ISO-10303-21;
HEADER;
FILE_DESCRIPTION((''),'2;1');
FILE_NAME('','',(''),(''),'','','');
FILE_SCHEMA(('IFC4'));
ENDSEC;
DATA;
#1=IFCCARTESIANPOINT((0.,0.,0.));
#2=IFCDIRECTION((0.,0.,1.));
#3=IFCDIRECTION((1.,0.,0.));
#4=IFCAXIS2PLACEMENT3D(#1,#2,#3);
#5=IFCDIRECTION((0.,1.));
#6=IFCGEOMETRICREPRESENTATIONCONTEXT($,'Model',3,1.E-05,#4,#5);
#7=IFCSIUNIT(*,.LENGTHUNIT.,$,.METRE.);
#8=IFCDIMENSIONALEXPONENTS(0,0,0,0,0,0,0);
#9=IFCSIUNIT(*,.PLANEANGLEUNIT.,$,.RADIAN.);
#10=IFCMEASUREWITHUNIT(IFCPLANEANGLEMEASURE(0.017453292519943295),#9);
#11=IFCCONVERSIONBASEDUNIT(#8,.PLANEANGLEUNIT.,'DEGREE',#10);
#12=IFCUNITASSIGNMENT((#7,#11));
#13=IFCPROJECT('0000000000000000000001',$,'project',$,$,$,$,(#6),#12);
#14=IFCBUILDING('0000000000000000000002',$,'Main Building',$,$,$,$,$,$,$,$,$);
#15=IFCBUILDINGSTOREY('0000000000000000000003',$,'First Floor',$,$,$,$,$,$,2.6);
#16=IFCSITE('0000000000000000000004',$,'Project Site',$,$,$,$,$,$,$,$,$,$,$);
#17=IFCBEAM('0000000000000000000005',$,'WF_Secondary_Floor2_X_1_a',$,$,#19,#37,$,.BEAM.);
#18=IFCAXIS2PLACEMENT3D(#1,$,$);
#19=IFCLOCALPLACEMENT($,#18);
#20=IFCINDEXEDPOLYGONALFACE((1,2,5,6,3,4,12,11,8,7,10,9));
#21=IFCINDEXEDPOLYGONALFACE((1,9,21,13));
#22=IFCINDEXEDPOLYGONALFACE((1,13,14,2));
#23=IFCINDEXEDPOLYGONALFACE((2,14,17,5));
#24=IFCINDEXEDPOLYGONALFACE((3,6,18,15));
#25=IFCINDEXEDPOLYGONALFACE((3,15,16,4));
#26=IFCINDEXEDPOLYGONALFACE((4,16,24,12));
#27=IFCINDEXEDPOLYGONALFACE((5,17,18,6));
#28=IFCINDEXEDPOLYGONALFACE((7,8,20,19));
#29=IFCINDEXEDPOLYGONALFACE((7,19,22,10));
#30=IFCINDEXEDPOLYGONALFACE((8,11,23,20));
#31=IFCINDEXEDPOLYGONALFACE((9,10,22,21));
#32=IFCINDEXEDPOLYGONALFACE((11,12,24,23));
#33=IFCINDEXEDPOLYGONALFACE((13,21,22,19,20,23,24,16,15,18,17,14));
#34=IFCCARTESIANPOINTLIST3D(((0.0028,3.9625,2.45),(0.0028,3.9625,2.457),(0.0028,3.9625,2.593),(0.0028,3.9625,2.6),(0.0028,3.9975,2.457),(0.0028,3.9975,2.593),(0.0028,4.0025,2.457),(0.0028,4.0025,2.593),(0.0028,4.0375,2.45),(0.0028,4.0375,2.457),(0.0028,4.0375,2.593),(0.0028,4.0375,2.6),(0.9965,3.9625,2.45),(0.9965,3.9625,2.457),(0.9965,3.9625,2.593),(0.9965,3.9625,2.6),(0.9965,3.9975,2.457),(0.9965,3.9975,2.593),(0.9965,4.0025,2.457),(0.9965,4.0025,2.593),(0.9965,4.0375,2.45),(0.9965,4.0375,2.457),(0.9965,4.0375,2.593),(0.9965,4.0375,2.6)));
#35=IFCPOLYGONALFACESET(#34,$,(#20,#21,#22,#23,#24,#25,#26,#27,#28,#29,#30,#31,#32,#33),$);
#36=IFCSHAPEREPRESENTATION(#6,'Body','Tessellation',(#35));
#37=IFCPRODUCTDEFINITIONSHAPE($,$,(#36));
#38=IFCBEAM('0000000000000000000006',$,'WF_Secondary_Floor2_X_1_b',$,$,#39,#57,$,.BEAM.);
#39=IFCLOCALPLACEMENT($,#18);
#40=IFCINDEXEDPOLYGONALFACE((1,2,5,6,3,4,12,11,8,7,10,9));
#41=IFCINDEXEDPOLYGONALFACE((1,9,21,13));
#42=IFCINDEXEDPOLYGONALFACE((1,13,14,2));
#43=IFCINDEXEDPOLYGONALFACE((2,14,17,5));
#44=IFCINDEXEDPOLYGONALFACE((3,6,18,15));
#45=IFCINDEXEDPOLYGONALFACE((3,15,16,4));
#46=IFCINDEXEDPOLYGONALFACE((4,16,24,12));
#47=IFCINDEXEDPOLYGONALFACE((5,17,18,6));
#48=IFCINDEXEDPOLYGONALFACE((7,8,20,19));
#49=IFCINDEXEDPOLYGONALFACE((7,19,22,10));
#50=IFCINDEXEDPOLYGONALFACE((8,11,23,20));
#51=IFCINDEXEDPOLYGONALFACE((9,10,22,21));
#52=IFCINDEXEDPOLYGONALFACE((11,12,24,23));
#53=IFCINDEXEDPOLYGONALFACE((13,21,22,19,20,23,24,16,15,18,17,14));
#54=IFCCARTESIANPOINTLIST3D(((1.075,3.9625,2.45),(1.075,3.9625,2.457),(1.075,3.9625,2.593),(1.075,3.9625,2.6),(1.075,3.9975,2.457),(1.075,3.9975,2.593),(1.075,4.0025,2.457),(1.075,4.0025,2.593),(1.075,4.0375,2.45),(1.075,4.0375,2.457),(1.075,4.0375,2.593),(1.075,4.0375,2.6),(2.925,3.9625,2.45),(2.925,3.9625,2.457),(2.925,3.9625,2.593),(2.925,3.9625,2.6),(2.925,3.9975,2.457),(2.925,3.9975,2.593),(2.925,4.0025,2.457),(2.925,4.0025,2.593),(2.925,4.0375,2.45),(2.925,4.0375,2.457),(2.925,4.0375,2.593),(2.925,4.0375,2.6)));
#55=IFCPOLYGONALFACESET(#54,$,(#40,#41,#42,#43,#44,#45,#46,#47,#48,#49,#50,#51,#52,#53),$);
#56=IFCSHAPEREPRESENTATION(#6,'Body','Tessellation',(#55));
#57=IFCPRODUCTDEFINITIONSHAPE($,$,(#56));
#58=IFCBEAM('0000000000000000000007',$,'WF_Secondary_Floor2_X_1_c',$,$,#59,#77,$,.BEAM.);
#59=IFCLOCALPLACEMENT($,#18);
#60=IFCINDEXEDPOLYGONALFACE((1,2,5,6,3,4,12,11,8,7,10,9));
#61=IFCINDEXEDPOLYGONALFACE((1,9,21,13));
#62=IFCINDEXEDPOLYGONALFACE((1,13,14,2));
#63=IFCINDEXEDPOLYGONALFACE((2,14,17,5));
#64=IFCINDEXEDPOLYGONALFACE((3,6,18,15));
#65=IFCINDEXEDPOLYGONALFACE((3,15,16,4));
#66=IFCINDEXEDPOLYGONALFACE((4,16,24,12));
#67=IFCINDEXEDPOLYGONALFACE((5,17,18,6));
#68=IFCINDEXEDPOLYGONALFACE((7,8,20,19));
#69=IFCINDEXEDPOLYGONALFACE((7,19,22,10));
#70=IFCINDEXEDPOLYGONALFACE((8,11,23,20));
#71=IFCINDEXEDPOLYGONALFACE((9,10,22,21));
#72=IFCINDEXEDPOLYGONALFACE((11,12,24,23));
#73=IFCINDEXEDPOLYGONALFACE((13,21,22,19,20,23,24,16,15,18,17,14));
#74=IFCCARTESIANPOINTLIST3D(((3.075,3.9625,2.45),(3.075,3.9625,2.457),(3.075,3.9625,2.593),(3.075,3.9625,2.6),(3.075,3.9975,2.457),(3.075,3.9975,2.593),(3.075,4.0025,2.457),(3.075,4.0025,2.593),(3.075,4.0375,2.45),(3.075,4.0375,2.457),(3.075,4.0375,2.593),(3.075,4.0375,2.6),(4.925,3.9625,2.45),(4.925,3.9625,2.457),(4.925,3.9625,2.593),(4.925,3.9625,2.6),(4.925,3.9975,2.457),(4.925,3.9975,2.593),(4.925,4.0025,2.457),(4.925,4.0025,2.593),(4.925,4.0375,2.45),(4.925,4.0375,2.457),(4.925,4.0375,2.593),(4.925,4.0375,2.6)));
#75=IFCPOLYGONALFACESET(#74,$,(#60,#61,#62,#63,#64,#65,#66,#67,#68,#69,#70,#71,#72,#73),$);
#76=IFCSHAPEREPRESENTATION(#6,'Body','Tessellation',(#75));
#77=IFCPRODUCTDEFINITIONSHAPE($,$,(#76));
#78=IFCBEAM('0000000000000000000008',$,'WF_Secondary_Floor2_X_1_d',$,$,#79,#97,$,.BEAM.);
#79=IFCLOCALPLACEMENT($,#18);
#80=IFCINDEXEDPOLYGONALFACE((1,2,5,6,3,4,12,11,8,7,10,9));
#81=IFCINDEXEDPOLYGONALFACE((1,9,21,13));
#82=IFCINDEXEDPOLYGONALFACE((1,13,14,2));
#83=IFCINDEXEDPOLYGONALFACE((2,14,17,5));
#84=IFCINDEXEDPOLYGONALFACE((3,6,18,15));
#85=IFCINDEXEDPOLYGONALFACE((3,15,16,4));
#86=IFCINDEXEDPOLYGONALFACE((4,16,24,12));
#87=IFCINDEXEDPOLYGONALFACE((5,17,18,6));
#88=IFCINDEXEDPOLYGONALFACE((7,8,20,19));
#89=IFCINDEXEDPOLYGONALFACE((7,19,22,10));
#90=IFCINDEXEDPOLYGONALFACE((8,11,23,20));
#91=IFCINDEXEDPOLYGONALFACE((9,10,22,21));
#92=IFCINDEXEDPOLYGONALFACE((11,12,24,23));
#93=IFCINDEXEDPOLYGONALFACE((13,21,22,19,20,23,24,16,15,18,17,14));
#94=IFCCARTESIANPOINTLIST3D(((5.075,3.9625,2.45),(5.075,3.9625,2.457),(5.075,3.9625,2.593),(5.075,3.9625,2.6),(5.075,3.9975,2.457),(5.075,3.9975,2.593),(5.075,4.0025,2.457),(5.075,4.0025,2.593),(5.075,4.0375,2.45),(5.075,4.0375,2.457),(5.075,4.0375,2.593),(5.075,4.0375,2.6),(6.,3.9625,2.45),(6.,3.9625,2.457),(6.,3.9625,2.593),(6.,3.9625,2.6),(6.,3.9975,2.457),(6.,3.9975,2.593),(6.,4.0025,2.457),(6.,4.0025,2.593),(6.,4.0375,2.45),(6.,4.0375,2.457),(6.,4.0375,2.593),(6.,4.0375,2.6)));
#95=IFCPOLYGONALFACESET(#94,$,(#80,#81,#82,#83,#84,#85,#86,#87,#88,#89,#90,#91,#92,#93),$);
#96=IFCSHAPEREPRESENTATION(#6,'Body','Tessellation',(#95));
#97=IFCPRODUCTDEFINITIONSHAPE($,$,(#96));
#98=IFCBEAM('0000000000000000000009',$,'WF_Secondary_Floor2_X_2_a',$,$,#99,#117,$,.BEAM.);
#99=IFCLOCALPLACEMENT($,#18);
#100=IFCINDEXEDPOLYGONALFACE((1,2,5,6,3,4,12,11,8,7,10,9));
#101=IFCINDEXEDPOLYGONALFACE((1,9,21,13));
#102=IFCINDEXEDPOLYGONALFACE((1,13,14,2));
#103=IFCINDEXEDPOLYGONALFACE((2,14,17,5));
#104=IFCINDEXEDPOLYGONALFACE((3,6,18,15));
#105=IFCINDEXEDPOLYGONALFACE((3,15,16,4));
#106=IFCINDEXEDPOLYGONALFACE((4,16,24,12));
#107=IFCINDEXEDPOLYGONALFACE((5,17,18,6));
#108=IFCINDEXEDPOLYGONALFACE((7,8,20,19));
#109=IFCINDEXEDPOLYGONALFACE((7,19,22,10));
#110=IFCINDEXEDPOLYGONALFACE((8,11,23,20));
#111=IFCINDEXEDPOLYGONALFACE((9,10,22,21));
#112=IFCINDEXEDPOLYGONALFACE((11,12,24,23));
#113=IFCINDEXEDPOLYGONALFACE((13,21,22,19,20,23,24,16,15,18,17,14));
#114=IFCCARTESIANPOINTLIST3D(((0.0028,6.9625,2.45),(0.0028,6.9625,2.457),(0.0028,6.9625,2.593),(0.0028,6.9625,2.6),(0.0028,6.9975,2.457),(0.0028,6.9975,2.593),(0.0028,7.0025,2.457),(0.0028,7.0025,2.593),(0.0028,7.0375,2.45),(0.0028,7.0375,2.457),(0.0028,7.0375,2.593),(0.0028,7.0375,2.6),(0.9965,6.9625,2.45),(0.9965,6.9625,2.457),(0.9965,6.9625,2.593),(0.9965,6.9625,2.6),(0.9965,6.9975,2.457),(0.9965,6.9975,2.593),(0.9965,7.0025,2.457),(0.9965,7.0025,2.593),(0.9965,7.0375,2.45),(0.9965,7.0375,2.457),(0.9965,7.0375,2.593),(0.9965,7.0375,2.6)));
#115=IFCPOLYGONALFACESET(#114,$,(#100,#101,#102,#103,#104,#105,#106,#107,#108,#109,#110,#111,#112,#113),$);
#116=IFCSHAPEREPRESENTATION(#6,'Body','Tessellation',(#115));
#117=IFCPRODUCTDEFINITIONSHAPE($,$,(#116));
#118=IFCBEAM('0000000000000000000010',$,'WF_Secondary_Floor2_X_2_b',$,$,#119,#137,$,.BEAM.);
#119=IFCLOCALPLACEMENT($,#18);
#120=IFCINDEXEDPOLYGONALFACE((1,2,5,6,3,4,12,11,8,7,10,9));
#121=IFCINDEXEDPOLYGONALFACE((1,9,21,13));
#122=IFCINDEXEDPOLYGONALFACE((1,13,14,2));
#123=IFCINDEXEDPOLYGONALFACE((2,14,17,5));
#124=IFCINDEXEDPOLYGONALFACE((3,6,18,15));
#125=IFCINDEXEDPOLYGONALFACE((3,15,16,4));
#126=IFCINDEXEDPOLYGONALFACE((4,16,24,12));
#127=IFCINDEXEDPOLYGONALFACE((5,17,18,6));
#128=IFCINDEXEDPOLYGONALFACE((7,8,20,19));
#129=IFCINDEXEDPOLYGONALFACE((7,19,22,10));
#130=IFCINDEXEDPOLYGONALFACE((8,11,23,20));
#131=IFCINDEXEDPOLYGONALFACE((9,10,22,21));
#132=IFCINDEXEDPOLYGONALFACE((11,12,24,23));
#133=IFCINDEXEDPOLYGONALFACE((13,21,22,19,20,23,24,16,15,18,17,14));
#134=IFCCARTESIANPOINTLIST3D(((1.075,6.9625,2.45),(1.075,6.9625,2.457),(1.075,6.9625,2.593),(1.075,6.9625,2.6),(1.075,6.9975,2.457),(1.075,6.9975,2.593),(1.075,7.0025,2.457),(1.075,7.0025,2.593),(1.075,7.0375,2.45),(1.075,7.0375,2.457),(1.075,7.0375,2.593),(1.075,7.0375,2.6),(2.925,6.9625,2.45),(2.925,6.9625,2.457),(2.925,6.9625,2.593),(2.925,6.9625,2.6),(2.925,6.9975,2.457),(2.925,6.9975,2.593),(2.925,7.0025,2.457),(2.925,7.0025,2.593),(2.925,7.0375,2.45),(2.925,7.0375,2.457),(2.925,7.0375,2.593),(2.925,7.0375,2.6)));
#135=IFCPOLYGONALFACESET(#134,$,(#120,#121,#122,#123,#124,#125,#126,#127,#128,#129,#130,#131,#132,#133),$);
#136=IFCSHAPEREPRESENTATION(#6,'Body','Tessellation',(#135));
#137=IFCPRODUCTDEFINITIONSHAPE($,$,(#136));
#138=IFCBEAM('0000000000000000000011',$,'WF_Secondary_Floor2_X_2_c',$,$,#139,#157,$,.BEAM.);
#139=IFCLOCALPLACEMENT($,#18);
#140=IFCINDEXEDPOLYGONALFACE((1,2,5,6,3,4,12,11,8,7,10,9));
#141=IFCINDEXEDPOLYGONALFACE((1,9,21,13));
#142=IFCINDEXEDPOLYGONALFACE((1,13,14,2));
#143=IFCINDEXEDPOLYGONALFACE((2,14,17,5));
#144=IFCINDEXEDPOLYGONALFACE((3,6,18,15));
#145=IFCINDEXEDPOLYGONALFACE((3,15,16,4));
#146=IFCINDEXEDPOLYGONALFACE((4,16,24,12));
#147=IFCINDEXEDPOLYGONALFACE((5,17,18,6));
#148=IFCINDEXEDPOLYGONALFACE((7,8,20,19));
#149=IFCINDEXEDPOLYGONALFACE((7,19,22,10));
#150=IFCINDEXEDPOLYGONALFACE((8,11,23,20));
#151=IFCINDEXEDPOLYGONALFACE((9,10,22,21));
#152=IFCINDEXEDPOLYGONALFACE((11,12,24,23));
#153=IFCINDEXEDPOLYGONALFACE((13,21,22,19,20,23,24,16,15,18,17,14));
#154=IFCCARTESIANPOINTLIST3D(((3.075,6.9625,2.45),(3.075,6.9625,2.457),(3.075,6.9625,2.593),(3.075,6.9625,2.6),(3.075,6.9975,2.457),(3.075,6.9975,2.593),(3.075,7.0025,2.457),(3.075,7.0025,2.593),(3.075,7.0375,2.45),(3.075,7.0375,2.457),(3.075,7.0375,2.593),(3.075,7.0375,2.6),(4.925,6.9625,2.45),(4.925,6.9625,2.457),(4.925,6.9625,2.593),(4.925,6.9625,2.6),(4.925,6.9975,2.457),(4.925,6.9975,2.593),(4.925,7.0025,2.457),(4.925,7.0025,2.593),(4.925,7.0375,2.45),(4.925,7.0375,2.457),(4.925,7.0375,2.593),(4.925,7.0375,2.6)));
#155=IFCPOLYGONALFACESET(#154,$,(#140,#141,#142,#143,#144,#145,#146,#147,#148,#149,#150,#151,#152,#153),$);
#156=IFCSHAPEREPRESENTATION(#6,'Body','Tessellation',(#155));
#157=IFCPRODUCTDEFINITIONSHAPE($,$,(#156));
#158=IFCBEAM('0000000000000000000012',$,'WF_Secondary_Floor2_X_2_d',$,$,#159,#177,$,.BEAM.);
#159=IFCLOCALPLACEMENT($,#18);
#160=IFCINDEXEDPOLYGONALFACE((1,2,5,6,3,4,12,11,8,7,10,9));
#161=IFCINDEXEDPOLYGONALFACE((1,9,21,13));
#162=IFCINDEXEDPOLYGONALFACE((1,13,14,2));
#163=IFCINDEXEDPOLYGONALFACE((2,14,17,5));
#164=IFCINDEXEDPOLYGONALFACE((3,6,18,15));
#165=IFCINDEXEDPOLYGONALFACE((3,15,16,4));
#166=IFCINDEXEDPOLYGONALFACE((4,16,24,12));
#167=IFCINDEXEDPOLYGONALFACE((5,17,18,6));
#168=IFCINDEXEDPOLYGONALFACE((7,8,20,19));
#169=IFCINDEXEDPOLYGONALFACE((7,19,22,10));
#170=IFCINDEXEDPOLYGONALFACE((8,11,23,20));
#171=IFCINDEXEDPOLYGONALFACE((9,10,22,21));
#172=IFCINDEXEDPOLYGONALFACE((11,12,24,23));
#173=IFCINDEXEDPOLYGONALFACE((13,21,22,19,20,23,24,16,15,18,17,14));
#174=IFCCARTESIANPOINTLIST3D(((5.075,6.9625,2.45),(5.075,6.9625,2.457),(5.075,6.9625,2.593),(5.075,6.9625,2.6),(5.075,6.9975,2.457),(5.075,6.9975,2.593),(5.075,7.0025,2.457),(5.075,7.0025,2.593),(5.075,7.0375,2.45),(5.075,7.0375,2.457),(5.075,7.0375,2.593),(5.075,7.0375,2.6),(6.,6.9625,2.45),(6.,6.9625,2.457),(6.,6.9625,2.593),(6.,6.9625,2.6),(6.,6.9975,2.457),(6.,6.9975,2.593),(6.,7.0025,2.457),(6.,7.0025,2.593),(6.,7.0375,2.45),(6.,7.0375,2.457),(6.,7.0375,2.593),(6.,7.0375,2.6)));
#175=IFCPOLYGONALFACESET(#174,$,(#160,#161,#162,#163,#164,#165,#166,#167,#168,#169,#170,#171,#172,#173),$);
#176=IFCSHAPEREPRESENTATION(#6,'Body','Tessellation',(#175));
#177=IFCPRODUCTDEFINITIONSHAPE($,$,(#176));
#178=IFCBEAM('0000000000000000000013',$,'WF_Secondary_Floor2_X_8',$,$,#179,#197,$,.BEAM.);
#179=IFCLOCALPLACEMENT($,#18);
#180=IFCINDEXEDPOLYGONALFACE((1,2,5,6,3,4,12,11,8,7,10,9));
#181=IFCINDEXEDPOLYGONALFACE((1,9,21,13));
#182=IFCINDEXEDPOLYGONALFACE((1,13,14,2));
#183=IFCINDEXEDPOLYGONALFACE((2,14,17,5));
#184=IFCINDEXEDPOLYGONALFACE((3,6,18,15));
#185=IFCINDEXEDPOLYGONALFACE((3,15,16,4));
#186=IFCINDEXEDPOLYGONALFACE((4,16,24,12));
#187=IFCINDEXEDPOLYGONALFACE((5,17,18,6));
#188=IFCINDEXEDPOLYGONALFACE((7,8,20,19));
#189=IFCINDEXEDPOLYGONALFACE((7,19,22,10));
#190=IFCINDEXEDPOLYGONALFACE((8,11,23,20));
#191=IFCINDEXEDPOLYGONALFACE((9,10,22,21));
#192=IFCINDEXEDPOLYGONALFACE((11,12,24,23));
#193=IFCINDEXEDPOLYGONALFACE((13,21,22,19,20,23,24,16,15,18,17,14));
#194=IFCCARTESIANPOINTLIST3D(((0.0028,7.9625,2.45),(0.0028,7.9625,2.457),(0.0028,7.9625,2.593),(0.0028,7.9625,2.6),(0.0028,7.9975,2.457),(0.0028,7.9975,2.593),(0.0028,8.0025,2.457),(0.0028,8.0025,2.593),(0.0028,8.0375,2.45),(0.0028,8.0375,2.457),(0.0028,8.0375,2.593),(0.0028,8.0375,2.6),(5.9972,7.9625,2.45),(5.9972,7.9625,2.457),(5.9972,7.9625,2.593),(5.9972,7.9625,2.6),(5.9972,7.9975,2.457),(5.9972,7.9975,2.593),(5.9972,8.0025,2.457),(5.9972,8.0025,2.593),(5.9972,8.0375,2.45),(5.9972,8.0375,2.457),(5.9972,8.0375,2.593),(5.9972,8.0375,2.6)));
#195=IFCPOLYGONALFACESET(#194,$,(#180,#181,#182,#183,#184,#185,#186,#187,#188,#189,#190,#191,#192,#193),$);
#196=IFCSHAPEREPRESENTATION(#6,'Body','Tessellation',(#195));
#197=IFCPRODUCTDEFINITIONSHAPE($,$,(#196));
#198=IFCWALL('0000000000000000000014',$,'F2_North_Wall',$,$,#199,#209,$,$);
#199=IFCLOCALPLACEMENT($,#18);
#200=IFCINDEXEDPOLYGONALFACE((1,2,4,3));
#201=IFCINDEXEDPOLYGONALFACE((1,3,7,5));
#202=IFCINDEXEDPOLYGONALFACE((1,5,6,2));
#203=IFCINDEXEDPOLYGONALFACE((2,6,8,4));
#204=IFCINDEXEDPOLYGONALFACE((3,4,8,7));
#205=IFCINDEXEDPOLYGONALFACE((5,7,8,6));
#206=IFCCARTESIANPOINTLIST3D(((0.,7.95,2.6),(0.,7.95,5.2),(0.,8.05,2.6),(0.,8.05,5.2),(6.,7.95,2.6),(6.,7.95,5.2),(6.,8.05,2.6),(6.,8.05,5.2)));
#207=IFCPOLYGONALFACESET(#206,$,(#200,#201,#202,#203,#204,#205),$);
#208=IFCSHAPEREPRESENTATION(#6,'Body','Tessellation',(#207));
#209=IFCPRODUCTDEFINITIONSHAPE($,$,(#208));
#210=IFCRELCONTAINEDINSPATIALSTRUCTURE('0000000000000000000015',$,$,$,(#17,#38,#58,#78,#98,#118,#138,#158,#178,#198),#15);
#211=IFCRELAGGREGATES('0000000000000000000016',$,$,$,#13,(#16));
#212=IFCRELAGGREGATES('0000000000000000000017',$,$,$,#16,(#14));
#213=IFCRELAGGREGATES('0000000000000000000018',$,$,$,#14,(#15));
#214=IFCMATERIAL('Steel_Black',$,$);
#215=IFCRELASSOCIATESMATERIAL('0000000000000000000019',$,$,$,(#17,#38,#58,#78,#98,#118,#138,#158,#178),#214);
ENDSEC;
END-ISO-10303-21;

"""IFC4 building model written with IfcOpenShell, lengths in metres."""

from ifc_helpers import new_model, entity, si_unit, converted_unit, direction, frame, frame_2d, origin, origin_with_axes, place, context, project, spatial, rectangle, i_section, extrude, material, element, save


model = new_model("IFC4")

# Units and contexts
model_context = context("Model", 3, precision=1e-05, world=origin_with_axes(), true_north=direction((0.0, 1.0)))
ifc_project = project(units=[si_unit("LENGTHUNIT", "METRE"), converted_unit("PLANEANGLEUNIT", "DEGREE", entity("IfcPlaneAngleMeasure", 0.017453292519943295), si_unit("PLANEANGLEUNIT", "RADIAN"), dimensions=[0, 0, 0, 0, 0, 0, 0])], contexts=[model_context])

# Site, building, storey
site = spatial("IfcSite", under=ifc_project, Name="Project Site")
building = spatial("IfcBuilding", under=site, Name="Main Building")
storey = spatial("IfcBuildingStorey", under=building, Name="First Floor", Elevation=2.6)

# Shared definitions
ifc_material = material(Name="Steel_Black")

# Beams
beam_1_placement = place(None, frame((0.0027, 4.0, 2.45), z_axis=(0.0, 0.0, 1.0), x_axis=(1.0, 0.0, 0.0)))
element("IfcBeam", 1, at=beam_1_placement, inside=storey, material=ifc_material, Name="WF_Secondary_Floor2_X_1_a", PredefinedType="BEAM", context=model_context, shape_type="SweptSolid", body=[
    extrude(i_section(OverallWidth=0.075, OverallDepth=0.15, WebThickness=0.005, FlangeThickness=0.007, at=frame_2d((0.0, 0.075))), frame((0.0, 0.0, 0.0), z_axis=(1.0, 0.0, 0.0), x_axis=(0.0, 1.0, 0.0)), (0.0, 0.0, 1.0), 0.9938),
])
for number, where, z_axis, x_axis, name in (
    (2, (1.075, 4.0, 2.45), (0.0, 0.0, 1.0), (1.0, 0.0, 0.0), "WF_Secondary_Floor2_X_1_b"),
    (3, (3.075, 4.0, 2.45), (0.0, 0.0, 1.0), (1.0, 0.0, 0.0), "WF_Secondary_Floor2_X_1_c"),
):
    element("IfcBeam", number, at=place(None, frame(where, z_axis=z_axis, x_axis=x_axis)), inside=storey, material=ifc_material, Name=name, PredefinedType="BEAM", context=model_context, shape_type="SweptSolid", body=[
        extrude(i_section(OverallWidth=0.075, OverallDepth=0.15, WebThickness=0.005, FlangeThickness=0.007, at=frame_2d((0.0, 0.075))), frame((0.0, 0.0, 0.0), z_axis=(1.0, 0.0, 0.0), x_axis=(0.0, 1.0, 0.0)), (0.0, 0.0, 1.0), 1.85),
    ])
beam_2_placement = place(None, frame((5.075, 4.0, 2.45), z_axis=(0.0, 0.0, 1.0), x_axis=(1.0, 0.0, 0.0)))
element("IfcBeam", 4, at=beam_2_placement, inside=storey, material=ifc_material, Name="WF_Secondary_Floor2_X_1_d", PredefinedType="BEAM", context=model_context, shape_type="SweptSolid", body=[
    extrude(i_section(OverallWidth=0.075, OverallDepth=0.15, WebThickness=0.005, FlangeThickness=0.007, at=frame_2d((0.0, 0.075))), frame((0.0, 0.0, 0.0), z_axis=(1.0, 0.0, 0.0), x_axis=(0.0, 1.0, 0.0)), (0.0, 0.0, 1.0), 0.925),
])
beam_3_placement = place(None, frame((0.0027, 7.0, 2.45), z_axis=(0.0, 0.0, 1.0), x_axis=(1.0, 0.0, 0.0)))
element("IfcBeam", 5, at=beam_3_placement, inside=storey, material=ifc_material, Name="WF_Secondary_Floor2_X_2_a", PredefinedType="BEAM", context=model_context, shape_type="SweptSolid", body=[
    extrude(i_section(OverallWidth=0.075, OverallDepth=0.15, WebThickness=0.005, FlangeThickness=0.007, at=frame_2d((0.0, 0.075))), frame((0.0, 0.0, 0.0), z_axis=(1.0, 0.0, 0.0), x_axis=(0.0, 1.0, 0.0)), (0.0, 0.0, 1.0), 0.9938),
])
for number, where, z_axis, x_axis, name in (
    (6, (1.075, 7.0, 2.45), (0.0, 0.0, 1.0), (1.0, 0.0, 0.0), "WF_Secondary_Floor2_X_2_b"),
    (7, (3.075, 7.0, 2.45), (0.0, 0.0, 1.0), (1.0, 0.0, 0.0), "WF_Secondary_Floor2_X_2_c"),
):
    element("IfcBeam", number, at=place(None, frame(where, z_axis=z_axis, x_axis=x_axis)), inside=storey, material=ifc_material, Name=name, PredefinedType="BEAM", context=model_context, shape_type="SweptSolid", body=[
        extrude(i_section(OverallWidth=0.075, OverallDepth=0.15, WebThickness=0.005, FlangeThickness=0.007, at=frame_2d((0.0, 0.075))), frame((0.0, 0.0, 0.0), z_axis=(1.0, 0.0, 0.0), x_axis=(0.0, 1.0, 0.0)), (0.0, 0.0, 1.0), 1.85),
    ])
beam_4_placement = place(None, frame((5.075, 7.0, 2.45), z_axis=(0.0, 0.0, 1.0), x_axis=(1.0, 0.0, 0.0)))
element("IfcBeam", 8, at=beam_4_placement, inside=storey, material=ifc_material, Name="WF_Secondary_Floor2_X_2_d", PredefinedType="BEAM", context=model_context, shape_type="SweptSolid", body=[
    extrude(i_section(OverallWidth=0.075, OverallDepth=0.15, WebThickness=0.005, FlangeThickness=0.007, at=frame_2d((0.0, 0.075))), frame((0.0, 0.0, 0.0), z_axis=(1.0, 0.0, 0.0), x_axis=(0.0, 1.0, 0.0)), (0.0, 0.0, 1.0), 0.925),
])
beam_5_placement = place(None, frame((0.0027, 8.0, 2.45), z_axis=(0.0, 0.0, 1.0), x_axis=(1.0, 0.0, 0.0)))
element("IfcBeam", 9, at=beam_5_placement, inside=storey, material=ifc_material, Name="WF_Secondary_Floor2_X_8", PredefinedType="BEAM", context=model_context, shape_type="SweptSolid", body=[
    extrude(i_section(OverallWidth=0.075, OverallDepth=0.15, WebThickness=0.005, FlangeThickness=0.007, at=frame_2d((0.0, 0.075))), frame((0.0, 0.0, 0.0), z_axis=(1.0, 0.0, 0.0), x_axis=(0.0, 1.0, 0.0)), (0.0, 0.0, 1.0), 5.9945),
])

# Wall
wall_1_placement = place(None, frame((0.0, 8.0, 2.6), z_axis=(0.0, 0.0, 1.0), x_axis=(1.0, 0.0, 0.0)))
element("IfcWall", 10, at=wall_1_placement, inside=storey, Name="F2_North_Wall", context=model_context, shape_type="SweptSolid", body=[
    extrude(rectangle(XDim=6.0, YDim=0.1, at=frame_2d((3.0, 0.0))), origin(), (0.0, 0.0, 1.0), 2.6),
])

save(model, "model.ifc")
